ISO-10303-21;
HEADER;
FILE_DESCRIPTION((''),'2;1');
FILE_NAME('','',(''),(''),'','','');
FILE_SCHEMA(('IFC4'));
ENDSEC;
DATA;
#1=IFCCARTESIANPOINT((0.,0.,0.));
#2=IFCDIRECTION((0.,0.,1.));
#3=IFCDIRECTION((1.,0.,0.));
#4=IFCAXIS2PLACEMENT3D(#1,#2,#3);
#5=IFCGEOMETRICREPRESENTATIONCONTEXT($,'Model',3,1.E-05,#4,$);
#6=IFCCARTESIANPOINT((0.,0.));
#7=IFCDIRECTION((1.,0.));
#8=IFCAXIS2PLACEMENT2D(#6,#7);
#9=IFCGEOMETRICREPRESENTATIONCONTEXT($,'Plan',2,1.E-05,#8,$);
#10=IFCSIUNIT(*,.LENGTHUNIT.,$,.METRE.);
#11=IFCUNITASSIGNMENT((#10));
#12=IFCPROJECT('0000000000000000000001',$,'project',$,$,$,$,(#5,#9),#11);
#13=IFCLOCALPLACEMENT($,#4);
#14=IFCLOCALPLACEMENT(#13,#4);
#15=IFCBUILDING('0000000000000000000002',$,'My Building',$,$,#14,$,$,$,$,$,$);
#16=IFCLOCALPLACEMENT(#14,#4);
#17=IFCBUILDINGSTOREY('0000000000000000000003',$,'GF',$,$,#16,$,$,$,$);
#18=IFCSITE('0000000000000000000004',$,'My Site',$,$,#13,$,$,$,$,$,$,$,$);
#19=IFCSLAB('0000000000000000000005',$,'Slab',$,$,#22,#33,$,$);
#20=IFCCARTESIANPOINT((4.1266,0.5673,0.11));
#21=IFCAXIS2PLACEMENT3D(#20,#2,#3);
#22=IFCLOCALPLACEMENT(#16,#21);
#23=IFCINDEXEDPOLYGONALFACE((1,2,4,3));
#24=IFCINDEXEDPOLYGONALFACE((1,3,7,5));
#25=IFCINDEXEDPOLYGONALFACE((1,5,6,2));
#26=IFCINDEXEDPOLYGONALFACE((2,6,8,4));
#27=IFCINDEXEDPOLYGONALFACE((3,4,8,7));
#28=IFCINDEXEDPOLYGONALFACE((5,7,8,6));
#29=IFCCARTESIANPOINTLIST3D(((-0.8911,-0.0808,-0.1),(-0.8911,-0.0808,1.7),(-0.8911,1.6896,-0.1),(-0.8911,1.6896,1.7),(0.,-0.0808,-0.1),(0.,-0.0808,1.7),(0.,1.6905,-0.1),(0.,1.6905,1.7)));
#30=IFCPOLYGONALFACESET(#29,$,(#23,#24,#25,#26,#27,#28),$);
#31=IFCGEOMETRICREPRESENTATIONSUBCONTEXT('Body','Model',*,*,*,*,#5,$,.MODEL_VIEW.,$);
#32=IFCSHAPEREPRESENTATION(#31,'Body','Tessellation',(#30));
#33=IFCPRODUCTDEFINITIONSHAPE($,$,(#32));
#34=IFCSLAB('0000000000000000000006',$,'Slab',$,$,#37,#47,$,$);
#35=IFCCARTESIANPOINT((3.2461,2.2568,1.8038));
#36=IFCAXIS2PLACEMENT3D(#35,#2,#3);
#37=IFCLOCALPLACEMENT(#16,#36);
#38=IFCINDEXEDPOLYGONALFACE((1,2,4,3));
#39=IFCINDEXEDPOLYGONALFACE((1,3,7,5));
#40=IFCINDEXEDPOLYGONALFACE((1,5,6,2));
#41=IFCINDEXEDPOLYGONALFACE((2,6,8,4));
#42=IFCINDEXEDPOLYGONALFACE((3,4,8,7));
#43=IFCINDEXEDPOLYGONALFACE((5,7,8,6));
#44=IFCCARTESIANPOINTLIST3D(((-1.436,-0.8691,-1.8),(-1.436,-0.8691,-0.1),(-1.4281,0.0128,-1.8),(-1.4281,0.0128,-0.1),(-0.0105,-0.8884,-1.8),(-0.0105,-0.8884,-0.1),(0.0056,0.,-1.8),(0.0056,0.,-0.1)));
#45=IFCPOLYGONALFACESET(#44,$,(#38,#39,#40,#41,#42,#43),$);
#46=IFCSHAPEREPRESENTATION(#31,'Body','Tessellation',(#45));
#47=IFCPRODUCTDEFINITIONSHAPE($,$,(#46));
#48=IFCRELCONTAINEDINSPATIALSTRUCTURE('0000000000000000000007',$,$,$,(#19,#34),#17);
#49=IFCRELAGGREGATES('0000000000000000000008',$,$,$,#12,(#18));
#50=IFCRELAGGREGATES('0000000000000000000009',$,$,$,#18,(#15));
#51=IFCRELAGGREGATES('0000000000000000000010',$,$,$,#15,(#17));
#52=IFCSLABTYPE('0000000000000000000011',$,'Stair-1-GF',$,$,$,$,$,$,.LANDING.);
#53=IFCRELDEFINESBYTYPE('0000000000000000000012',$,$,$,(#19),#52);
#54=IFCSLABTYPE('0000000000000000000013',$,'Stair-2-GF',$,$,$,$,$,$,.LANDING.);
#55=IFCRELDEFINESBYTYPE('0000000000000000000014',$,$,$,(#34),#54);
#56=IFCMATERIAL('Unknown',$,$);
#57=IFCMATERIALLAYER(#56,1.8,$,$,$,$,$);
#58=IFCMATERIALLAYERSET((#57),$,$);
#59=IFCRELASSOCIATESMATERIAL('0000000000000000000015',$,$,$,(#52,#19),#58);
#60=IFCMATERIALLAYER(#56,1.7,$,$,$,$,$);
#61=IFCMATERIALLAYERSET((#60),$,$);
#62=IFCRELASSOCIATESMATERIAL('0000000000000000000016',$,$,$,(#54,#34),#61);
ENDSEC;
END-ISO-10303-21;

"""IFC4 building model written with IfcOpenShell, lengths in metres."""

from ifc_helpers import new_model, si_unit, frame, origin_with_axes, origin_2d_with_axis, place, context, subcontext, project, spatial, indexed_curve, outline, extrude, material, layer, layer_set, layer_usage, type_object, element, save


model = new_model("IFC4")

# Units and contexts
model_context = context("Model", 3, precision=1e-05, world=origin_with_axes())
plan_context = context("Plan", 2, precision=1e-05, world=origin_2d_with_axis())
body_context_1 = subcontext(model_context, "Body", "Model", "MODEL_VIEW")
ifc_project = project(units=[si_unit("LENGTHUNIT", "METRE")], contexts=[model_context, plan_context])

# Site, building, storey
site_placement = place(None, origin_with_axes())
site = spatial("IfcSite", under=ifc_project, at=site_placement, Name="My Site")
building_placement = place(site_placement, origin_with_axes())
building = spatial("IfcBuilding", under=site, at=building_placement, Name="My Building")
storey_placement = place(building_placement, origin_with_axes())
storey = spatial("IfcBuildingStorey", under=building, at=storey_placement, Name="GF")

# Shared definitions
ifc_material = material(Name="Unknown")

# Slabs
ifc_layer_1 = layer(ifc_material, 1.8)
ifc_layer_set_1 = layer_set([ifc_layer_1])
ifc_layer_usage_1 = layer_usage(ifc_layer_set_1, "AXIS3", "POSITIVE", -0.1)
slab_type_1 = type_object("IfcSlabType", Name="Stair-1-GF", PredefinedType="LANDING", material=ifc_layer_set_1)
slab_1_placement = place(storey_placement, frame((4.1266, 0.5673, 0.11), z_axis=(0.0, 0.0, 1.0), x_axis=(1.0, 0.0, 0.0)))
element("IfcSlab", 1, at=slab_1_placement, inside=storey, type_object=slab_type_1, material=ifc_layer_usage_1, Name="Slab", context=body_context_1, shape_type="SweptSolid", body=[
    extrude(outline(indexed_curve([(0.0, -0.0808), (0.0, 1.6905), (-0.8911, 1.6896), (-0.8911, -0.0808), (0.0, -0.0808)])), frame((0.0, 0.0, -0.1), z_axis=(0.0, 0.0, 1.0), x_axis=(1.0, 0.0, 0.0)), (0.0, 0.0, 1.0), 1.8),
])
ifc_layer_2 = layer(ifc_material, 1.7)
ifc_layer_set_2 = layer_set([ifc_layer_2])
ifc_layer_usage_2 = layer_usage(ifc_layer_set_2, "AXIS3", "POSITIVE", -1.8)
slab_type_2 = type_object("IfcSlabType", Name="Stair-2-GF", PredefinedType="LANDING", material=ifc_layer_set_2)
slab_2_placement = place(storey_placement, frame((3.2461, 2.2568, 1.8038), z_axis=(0.0, 0.0, 1.0), x_axis=(1.0, 0.0, 0.0)))
element("IfcSlab", 2, at=slab_2_placement, inside=storey, type_object=slab_type_2, material=ifc_layer_usage_2, Name="Slab", context=body_context_1, shape_type="SweptSolid", body=[
    extrude(outline(indexed_curve([(-1.4281, 0.0128), (-1.436, -0.8691), (-0.0105, -0.8884), (0.0056, 0.0), (-1.4281, 0.0128)])), frame((0.0, 0.0, -1.8), z_axis=(0.0, 0.0, 1.0), x_axis=(1.0, 0.0, 0.0)), (0.0, 0.0, 1.0), 1.7),
])

save(model, "model.ifc")
